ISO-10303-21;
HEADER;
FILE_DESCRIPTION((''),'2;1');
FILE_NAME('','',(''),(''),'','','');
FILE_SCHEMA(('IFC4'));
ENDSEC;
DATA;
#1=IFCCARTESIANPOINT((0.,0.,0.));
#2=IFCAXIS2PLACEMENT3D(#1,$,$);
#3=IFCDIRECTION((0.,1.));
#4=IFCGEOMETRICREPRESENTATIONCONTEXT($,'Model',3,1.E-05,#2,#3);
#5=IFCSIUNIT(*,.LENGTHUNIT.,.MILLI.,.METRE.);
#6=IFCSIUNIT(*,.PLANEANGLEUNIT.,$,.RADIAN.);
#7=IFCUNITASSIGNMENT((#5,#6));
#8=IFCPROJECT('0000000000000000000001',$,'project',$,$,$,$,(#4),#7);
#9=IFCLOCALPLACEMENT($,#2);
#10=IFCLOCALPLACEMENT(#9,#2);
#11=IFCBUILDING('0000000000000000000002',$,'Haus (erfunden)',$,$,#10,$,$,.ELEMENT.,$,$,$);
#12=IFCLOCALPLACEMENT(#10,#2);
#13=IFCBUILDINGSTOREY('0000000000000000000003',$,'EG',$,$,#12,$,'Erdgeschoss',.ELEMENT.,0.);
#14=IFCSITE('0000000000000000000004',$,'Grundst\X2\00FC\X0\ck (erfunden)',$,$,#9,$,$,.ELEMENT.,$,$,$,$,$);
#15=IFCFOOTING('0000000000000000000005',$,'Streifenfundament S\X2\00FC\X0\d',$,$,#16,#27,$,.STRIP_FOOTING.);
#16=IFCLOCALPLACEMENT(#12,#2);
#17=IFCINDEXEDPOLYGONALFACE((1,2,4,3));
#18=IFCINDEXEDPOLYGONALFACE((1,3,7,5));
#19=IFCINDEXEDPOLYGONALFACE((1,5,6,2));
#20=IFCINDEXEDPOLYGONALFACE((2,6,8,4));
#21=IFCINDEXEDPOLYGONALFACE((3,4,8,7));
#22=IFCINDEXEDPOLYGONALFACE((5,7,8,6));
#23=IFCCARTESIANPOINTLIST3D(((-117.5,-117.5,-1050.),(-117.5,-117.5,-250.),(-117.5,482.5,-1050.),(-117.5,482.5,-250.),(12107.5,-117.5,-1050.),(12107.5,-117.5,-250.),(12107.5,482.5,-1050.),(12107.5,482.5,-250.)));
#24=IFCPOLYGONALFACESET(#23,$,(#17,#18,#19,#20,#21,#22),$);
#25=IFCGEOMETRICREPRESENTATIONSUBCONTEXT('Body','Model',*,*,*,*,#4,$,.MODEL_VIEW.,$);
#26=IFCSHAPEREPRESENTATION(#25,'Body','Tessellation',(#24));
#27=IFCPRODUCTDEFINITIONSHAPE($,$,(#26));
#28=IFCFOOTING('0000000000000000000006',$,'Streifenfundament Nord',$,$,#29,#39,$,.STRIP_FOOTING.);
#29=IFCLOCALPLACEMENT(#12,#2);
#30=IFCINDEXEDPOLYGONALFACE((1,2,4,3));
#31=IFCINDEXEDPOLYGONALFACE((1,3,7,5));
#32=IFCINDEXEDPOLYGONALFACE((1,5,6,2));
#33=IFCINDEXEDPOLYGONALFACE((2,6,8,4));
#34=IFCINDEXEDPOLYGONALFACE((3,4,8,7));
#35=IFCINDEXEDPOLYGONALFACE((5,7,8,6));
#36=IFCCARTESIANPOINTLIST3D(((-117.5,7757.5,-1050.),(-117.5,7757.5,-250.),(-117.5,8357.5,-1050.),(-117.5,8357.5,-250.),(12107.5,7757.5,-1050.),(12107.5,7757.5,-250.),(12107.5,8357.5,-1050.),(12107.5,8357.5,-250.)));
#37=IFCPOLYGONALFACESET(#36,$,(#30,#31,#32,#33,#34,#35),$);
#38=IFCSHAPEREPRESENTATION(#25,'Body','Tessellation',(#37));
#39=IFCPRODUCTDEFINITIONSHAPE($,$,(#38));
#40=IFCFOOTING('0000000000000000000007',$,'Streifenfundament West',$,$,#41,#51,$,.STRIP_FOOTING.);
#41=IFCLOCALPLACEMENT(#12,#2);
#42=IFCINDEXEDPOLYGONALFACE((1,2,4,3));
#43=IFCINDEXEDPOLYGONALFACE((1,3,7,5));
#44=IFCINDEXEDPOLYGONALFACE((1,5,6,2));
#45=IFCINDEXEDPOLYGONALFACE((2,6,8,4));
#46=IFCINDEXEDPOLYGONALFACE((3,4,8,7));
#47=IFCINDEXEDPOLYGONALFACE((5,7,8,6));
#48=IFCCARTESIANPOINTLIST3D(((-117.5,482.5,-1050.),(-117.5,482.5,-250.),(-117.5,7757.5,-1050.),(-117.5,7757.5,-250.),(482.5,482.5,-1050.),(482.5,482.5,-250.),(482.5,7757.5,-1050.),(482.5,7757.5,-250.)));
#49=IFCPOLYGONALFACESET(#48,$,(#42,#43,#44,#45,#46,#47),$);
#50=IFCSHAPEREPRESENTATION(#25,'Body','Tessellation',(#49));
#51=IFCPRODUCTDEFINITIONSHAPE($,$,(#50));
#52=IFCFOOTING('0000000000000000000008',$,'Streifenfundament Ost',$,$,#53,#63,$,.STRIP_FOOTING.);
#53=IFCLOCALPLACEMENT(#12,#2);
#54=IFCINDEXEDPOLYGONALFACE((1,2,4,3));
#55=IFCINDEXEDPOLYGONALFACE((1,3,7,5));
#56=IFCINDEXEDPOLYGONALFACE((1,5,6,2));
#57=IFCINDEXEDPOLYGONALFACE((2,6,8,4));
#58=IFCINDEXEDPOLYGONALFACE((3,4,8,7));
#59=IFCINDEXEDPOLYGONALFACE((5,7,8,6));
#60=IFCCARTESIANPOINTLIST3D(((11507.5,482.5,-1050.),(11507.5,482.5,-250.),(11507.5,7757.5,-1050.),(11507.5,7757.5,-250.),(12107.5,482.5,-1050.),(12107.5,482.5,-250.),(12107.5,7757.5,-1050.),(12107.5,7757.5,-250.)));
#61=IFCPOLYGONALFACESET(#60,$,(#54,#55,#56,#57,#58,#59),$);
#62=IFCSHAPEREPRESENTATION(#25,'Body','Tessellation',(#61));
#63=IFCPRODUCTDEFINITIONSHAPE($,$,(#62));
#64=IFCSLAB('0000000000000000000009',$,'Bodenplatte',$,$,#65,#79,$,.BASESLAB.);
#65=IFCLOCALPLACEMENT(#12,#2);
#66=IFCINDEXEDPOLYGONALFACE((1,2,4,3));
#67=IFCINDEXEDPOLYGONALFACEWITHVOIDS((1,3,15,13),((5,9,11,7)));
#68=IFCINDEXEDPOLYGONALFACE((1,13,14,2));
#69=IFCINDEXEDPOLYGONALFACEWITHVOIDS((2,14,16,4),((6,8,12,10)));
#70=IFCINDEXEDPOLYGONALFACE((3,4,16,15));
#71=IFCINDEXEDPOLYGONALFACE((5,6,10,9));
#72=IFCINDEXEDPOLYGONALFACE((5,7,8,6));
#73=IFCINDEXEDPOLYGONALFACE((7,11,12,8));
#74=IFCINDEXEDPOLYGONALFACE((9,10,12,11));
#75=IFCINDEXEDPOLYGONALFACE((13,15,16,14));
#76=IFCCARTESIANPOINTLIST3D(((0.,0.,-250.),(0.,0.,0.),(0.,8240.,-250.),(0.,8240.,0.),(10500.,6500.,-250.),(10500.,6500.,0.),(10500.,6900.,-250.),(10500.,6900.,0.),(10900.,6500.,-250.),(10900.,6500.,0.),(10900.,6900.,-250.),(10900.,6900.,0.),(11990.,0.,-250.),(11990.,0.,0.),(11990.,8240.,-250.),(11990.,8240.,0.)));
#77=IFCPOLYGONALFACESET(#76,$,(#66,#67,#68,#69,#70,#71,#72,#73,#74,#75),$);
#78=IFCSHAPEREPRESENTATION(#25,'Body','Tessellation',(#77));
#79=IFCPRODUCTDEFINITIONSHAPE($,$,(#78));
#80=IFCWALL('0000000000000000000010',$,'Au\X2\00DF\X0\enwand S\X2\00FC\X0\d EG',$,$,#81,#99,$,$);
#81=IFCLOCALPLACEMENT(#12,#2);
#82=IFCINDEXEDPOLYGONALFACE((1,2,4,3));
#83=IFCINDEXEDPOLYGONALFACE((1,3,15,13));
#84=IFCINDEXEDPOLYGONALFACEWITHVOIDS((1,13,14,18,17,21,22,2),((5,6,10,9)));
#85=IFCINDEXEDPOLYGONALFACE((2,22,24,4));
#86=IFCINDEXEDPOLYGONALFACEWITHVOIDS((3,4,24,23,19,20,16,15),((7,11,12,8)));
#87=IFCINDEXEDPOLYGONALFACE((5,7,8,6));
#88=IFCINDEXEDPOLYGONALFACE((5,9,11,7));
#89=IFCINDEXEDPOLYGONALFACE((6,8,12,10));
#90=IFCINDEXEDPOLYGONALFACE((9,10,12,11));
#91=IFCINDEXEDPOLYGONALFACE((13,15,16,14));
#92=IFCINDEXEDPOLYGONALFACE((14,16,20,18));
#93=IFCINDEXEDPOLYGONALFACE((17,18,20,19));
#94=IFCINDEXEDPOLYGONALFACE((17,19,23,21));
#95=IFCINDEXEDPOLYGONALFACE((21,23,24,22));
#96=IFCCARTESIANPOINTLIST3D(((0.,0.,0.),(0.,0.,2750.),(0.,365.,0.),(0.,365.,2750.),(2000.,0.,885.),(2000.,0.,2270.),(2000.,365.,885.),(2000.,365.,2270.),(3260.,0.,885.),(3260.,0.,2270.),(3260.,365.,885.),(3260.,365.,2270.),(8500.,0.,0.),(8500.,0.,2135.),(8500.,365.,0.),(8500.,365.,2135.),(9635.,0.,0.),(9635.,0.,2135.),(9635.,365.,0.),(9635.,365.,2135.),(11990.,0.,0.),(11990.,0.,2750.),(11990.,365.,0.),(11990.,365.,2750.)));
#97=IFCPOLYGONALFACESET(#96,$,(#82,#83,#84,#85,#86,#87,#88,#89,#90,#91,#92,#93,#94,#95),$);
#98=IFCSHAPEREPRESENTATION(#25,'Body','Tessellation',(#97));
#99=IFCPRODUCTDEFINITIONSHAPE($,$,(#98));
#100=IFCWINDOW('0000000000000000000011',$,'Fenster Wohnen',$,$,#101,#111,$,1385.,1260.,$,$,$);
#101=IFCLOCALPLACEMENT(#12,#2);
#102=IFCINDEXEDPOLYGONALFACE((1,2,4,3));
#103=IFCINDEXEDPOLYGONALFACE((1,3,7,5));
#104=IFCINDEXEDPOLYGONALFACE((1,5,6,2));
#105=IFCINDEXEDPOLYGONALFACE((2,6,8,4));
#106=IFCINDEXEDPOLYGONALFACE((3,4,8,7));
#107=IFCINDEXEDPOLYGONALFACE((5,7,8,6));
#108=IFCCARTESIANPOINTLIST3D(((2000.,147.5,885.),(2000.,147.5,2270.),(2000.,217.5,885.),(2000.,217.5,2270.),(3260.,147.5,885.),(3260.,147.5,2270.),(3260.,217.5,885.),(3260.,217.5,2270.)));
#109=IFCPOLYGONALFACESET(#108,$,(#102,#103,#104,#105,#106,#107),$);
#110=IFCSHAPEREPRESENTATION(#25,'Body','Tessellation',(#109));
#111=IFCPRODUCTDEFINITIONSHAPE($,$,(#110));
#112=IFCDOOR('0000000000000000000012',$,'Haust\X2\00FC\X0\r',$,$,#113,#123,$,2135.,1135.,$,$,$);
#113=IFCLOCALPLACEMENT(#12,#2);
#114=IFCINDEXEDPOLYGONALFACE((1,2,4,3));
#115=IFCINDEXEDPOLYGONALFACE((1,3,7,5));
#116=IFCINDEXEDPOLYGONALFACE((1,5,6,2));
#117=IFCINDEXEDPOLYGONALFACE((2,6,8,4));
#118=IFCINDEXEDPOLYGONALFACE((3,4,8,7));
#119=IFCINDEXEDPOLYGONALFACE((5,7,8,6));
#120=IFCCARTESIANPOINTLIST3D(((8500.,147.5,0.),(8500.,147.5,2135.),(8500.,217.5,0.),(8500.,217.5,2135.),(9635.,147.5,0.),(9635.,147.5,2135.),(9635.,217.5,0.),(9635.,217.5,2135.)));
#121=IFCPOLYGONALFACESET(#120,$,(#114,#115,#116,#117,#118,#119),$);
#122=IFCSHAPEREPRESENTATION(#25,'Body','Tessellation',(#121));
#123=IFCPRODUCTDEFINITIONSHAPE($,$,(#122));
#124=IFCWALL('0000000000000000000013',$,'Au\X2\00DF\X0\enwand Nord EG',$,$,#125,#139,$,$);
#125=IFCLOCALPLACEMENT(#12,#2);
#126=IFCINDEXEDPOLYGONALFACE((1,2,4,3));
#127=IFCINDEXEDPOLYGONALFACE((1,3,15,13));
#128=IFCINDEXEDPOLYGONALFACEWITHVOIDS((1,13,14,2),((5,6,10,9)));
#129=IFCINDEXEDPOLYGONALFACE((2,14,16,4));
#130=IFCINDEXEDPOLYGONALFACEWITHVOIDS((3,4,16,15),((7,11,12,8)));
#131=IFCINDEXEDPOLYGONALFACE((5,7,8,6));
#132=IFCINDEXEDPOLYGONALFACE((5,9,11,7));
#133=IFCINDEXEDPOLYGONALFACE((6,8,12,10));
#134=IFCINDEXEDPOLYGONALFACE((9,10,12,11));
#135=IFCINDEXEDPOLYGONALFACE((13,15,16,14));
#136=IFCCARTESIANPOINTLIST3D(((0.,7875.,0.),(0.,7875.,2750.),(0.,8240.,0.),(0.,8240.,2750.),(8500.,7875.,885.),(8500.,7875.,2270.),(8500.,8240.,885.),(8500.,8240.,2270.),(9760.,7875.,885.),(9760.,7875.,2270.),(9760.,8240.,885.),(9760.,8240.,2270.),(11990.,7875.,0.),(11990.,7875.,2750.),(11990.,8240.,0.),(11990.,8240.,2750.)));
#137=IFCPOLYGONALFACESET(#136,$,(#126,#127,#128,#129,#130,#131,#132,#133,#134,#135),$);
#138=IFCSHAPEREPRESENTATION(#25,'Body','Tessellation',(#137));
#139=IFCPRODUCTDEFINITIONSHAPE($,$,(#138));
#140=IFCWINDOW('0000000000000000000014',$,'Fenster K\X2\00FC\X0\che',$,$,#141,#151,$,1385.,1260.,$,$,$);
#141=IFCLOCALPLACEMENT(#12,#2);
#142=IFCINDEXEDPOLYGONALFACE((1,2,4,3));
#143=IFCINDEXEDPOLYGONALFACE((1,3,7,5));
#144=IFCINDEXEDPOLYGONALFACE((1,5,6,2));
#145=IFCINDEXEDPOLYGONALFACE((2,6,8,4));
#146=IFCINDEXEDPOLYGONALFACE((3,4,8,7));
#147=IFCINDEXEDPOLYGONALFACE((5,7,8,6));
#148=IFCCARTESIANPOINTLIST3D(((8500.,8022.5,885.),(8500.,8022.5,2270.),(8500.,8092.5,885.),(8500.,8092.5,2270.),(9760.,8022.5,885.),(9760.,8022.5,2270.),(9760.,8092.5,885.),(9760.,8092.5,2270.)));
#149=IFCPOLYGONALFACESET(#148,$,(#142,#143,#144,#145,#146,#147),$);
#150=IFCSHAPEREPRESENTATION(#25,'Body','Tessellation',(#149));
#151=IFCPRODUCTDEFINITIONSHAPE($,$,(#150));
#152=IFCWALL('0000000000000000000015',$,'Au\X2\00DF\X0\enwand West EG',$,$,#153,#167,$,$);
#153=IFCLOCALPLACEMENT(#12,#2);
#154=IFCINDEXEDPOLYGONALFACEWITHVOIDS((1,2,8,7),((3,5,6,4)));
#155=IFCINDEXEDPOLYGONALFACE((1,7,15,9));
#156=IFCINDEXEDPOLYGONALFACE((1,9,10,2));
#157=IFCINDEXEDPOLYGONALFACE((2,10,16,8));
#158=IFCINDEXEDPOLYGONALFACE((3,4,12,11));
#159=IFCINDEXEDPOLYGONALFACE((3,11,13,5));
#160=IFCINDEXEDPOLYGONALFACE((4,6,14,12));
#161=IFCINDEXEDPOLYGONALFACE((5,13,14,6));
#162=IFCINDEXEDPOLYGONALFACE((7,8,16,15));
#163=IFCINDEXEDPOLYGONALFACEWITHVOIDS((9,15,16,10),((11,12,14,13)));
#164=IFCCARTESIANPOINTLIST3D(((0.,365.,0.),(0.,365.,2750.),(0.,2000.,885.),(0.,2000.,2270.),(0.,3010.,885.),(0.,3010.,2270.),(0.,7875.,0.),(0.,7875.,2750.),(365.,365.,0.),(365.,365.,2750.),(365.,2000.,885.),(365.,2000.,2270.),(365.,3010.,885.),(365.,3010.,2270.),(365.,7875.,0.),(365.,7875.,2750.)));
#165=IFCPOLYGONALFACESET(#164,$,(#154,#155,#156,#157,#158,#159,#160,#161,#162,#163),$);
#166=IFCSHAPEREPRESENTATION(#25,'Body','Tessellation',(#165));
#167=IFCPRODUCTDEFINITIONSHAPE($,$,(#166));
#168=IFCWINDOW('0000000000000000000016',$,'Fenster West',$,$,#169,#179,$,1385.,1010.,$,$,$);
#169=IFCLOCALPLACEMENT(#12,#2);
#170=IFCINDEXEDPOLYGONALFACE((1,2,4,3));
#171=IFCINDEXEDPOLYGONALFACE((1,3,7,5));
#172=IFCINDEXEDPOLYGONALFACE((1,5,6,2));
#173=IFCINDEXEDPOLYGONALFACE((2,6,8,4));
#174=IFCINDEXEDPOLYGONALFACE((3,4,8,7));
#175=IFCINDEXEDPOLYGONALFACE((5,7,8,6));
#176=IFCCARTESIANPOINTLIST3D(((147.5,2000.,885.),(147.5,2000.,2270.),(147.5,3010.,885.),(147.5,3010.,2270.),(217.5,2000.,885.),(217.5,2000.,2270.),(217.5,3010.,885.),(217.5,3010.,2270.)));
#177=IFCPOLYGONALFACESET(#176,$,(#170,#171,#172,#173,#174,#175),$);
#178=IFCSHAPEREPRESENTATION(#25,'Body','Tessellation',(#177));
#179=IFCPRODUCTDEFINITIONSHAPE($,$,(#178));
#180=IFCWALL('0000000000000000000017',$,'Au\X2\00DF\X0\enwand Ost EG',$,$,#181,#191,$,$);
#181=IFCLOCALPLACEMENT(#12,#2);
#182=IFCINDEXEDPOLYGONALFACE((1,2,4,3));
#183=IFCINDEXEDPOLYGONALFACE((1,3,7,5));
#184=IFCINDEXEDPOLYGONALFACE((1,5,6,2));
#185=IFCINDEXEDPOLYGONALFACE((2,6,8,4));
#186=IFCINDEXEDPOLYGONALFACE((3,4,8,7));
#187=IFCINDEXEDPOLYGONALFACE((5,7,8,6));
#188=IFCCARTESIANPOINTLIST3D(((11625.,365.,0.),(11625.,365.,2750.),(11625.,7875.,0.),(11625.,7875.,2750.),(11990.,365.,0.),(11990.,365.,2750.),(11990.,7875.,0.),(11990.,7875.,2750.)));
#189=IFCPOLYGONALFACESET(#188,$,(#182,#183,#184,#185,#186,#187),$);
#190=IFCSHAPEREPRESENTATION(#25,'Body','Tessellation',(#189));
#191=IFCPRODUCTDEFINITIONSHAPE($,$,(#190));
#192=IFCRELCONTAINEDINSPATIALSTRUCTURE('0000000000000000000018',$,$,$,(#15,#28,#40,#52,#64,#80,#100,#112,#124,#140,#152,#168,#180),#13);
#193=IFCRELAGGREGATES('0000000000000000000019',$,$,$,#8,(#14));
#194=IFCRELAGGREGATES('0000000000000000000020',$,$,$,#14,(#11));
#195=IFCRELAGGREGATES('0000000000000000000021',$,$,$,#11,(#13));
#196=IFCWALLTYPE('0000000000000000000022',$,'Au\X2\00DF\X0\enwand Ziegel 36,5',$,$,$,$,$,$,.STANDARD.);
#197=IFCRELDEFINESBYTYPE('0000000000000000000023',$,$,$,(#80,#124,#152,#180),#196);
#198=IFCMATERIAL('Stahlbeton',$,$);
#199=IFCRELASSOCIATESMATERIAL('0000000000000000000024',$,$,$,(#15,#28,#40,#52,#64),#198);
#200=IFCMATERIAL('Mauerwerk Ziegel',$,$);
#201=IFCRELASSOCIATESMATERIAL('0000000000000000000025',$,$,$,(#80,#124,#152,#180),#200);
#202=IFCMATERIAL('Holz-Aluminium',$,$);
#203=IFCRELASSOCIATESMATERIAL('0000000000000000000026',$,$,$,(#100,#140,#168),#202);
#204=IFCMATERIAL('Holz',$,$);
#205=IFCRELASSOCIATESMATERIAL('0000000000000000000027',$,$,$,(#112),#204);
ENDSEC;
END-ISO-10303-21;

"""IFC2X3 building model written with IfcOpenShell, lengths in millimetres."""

from ifc_helpers import new_model, si_unit, direction, frame, frame_2d, origin, place, context, subcontext, project, spatial, rectangle, extrude, material, type_object, element, fill, save


model = new_model("IFC2X3")

# Units and contexts
model_context = context("Model", 3, precision=1e-05, world=origin(), true_north=direction((0.0, 1.0)))
body_context = subcontext(model_context, "Body", "Model", "MODEL_VIEW")
ifc_project = project(units=[si_unit("LENGTHUNIT", "METRE", prefix="MILLI"), si_unit("PLANEANGLEUNIT", "RADIAN")], contexts=[model_context])

# Site, building, storey
site_placement = place(None, origin())
site = spatial("IfcSite", under=ifc_project, at=site_placement, Name="Grundstück (erfunden)", CompositionType="ELEMENT")
building_placement = place(site_placement, origin())
building = spatial("IfcBuilding", under=site, at=building_placement, Name="Haus (erfunden)", CompositionType="ELEMENT")
storey_placement = place(building_placement, origin())
storey = spatial("IfcBuildingStorey", under=building, at=storey_placement, Name="EG", LongName="Erdgeschoss", CompositionType="ELEMENT", Elevation=0.0)

# Footings
ifc_material_1 = material(Name="Stahlbeton")
for number, where, name in (
    (1, (-117.5, -117.5, -1050.0), "Streifenfundament Süd"),
    (2, (-117.5, 7757.5, -1050.0), "Streifenfundament Nord"),
):
    element("IfcFooting", number, at=place(storey_placement, frame(where)), inside=storey, material=ifc_material_1, Name=name, PredefinedType="STRIP_FOOTING", context=body_context, shape_type="SweptSolid", body=[
        extrude(rectangle(XDim=12225.0, YDim=600.0, at=frame_2d((6112.5, 300.0))), origin(), (0.0, 0.0, 1.0), 800.0),
    ])
for number, where, name in (
    (3, (-117.5, 482.5, -1050.0), "Streifenfundament West"),
    (4, (11507.5, 482.5, -1050.0), "Streifenfundament Ost"),
):
    element("IfcFooting", number, at=place(storey_placement, frame(where)), inside=storey, material=ifc_material_1, Name=name, PredefinedType="STRIP_FOOTING", context=body_context, shape_type="SweptSolid", body=[
        extrude(rectangle(XDim=600.0, YDim=7275.0, at=frame_2d((300.0, 3637.5))), origin(), (0.0, 0.0, 1.0), 800.0),
    ])

# Slab, opening
slab_placement = place(storey_placement, frame((0.0, 0.0, -250.0)))
slab = element("IfcSlab", 5, at=slab_placement, inside=storey, material=ifc_material_1, Name="Bodenplatte", PredefinedType="BASESLAB", context=body_context, shape_type="SweptSolid", body=[
    extrude(rectangle(XDim=11990.0, YDim=8240.0, at=frame_2d((5995.0, 4120.0))), origin(), (0.0, 0.0, 1.0), 250.0),
])
opening_1_placement = place(slab_placement, frame((10500.0, 6500.0, -50.0)))
element("IfcOpeningElement", 6, at=opening_1_placement, cuts=slab, context=body_context, shape_type="SweptSolid", body=[
    extrude(rectangle(XDim=400.0, YDim=400.0, at=frame_2d((200.0, 200.0))), origin(), (0.0, 0.0, 1.0), 350.0),
])

# Wall, openings, window, door
ifc_material_2 = material(Name="Mauerwerk Ziegel")
wall_type_1 = type_object("IfcWallType", Name="Außenwand Ziegel 36,5", PredefinedType="STANDARD")
wall_1_placement = place(storey_placement, origin())
wall_1 = element("IfcWall", 7, at=wall_1_placement, inside=storey, type_object=wall_type_1, material=ifc_material_2, Name="Außenwand Süd EG", context=body_context, shape_type="SweptSolid", body=[
    extrude(rectangle(XDim=11990.0, YDim=365.0, at=frame_2d((5995.0, 182.5))), origin(), (0.0, 0.0, 1.0), 2750.0),
])
opening_2_placement = place(wall_1_placement, frame((2000.0, -50.0, 885.0)))
opening_2 = element("IfcOpeningElement", 8, at=opening_2_placement, cuts=wall_1, context=body_context, shape_type="SweptSolid", body=[
    extrude(rectangle(XDim=1260.0, YDim=465.0, at=frame_2d((630.0, 232.5))), origin(), (0.0, 0.0, 1.0), 1385.0),
])
opening_3_placement = place(wall_1_placement, frame((8500.0, -50.0, 0.0)))
opening_3 = element("IfcOpeningElement", 9, at=opening_3_placement, cuts=wall_1, context=body_context, shape_type="SweptSolid", body=[
    extrude(rectangle(XDim=1135.0, YDim=465.0, at=frame_2d((567.5, 232.5))), origin(), (0.0, 0.0, 1.0), 2135.0),
])
ifc_material_3 = material(Name="Holz-Aluminium")
window_1_placement = place(opening_2_placement, frame((0.0, 197.5, 0.0)))
window_1 = element("IfcWindow", 10, at=window_1_placement, inside=storey, material=ifc_material_3, Name="Fenster Wohnen", OverallHeight=1385.0, OverallWidth=1260.0, context=body_context, shape_type="SweptSolid", body=[
    extrude(rectangle(XDim=1260.0, YDim=70.0, at=frame_2d((630.0, 35.0))), origin(), (0.0, 0.0, 1.0), 1385.0),
])
fill(opening_2, window_1)
ifc_material_4 = material(Name="Holz")
door_1_placement = place(opening_3_placement, frame((0.0, 197.5, 0.0)))
door_1 = element("IfcDoor", 11, at=door_1_placement, inside=storey, material=ifc_material_4, Name="Haustür", OverallHeight=2135.0, OverallWidth=1135.0, context=body_context, shape_type="SweptSolid", body=[
    extrude(rectangle(XDim=1135.0, YDim=70.0, at=frame_2d((567.5, 35.0))), origin(), (0.0, 0.0, 1.0), 2135.0),
])
fill(opening_3, door_1)

# Walls, openings, windows
wall_2_placement = place(storey_placement, frame((0.0, 7875.0, 0.0)))
wall_2 = element("IfcWall", 12, at=wall_2_placement, inside=storey, type_object=wall_type_1, material=ifc_material_2, Name="Außenwand Nord EG", context=body_context, shape_type="SweptSolid", body=[
    extrude(rectangle(XDim=11990.0, YDim=365.0, at=frame_2d((5995.0, 182.5))), origin(), (0.0, 0.0, 1.0), 2750.0),
])
opening_4_placement = place(wall_2_placement, frame((8500.0, -50.0, 885.0)))
opening_4 = element("IfcOpeningElement", 13, at=opening_4_placement, cuts=wall_2, context=body_context, shape_type="SweptSolid", body=[
    extrude(rectangle(XDim=1260.0, YDim=465.0, at=frame_2d((630.0, 232.5))), origin(), (0.0, 0.0, 1.0), 1385.0),
])
window_2_placement = place(opening_4_placement, frame((0.0, 197.5, 0.0)))
window_2 = element("IfcWindow", 14, at=window_2_placement, inside=storey, material=ifc_material_3, Name="Fenster Küche", OverallHeight=1385.0, OverallWidth=1260.0, context=body_context, shape_type="SweptSolid", body=[
    extrude(rectangle(XDim=1260.0, YDim=70.0, at=frame_2d((630.0, 35.0))), origin(), (0.0, 0.0, 1.0), 1385.0),
])
fill(opening_4, window_2)
wall_3_placement = place(storey_placement, frame((0.0, 365.0, 0.0)))
wall_3 = element("IfcWall", 15, at=wall_3_placement, inside=storey, type_object=wall_type_1, material=ifc_material_2, Name="Außenwand West EG", context=body_context, shape_type="SweptSolid", body=[
    extrude(rectangle(XDim=365.0, YDim=7510.0, at=frame_2d((182.5, 3755.0))), origin(), (0.0, 0.0, 1.0), 2750.0),
])
opening_5_placement = place(wall_3_placement, frame((-50.0, 1635.0, 885.0)))
opening_5 = element("IfcOpeningElement", 16, at=opening_5_placement, cuts=wall_3, context=body_context, shape_type="SweptSolid", body=[
    extrude(rectangle(XDim=465.0, YDim=1010.0, at=frame_2d((232.5, 505.0))), origin(), (0.0, 0.0, 1.0), 1385.0),
])
window_3_placement = place(opening_5_placement, frame((197.5, 0.0, 0.0)))
window_3 = element("IfcWindow", 17, at=window_3_placement, inside=storey, material=ifc_material_3, Name="Fenster West", OverallHeight=1385.0, OverallWidth=1010.0, context=body_context, shape_type="SweptSolid", body=[
    extrude(rectangle(XDim=70.0, YDim=1010.0, at=frame_2d((35.0, 505.0))), origin(), (0.0, 0.0, 1.0), 1385.0),
])
fill(opening_5, window_3)

# Wall
wall_4_placement = place(storey_placement, frame((11625.0, 365.0, 0.0)))
element("IfcWall", 18, at=wall_4_placement, inside=storey, type_object=wall_type_1, material=ifc_material_2, Name="Außenwand Ost EG", context=body_context, shape_type="SweptSolid", body=[
    extrude(rectangle(XDim=365.0, YDim=7510.0, at=frame_2d((182.5, 3755.0))), origin(), (0.0, 0.0, 1.0), 2750.0),
])

save(model, "model.ifc")
